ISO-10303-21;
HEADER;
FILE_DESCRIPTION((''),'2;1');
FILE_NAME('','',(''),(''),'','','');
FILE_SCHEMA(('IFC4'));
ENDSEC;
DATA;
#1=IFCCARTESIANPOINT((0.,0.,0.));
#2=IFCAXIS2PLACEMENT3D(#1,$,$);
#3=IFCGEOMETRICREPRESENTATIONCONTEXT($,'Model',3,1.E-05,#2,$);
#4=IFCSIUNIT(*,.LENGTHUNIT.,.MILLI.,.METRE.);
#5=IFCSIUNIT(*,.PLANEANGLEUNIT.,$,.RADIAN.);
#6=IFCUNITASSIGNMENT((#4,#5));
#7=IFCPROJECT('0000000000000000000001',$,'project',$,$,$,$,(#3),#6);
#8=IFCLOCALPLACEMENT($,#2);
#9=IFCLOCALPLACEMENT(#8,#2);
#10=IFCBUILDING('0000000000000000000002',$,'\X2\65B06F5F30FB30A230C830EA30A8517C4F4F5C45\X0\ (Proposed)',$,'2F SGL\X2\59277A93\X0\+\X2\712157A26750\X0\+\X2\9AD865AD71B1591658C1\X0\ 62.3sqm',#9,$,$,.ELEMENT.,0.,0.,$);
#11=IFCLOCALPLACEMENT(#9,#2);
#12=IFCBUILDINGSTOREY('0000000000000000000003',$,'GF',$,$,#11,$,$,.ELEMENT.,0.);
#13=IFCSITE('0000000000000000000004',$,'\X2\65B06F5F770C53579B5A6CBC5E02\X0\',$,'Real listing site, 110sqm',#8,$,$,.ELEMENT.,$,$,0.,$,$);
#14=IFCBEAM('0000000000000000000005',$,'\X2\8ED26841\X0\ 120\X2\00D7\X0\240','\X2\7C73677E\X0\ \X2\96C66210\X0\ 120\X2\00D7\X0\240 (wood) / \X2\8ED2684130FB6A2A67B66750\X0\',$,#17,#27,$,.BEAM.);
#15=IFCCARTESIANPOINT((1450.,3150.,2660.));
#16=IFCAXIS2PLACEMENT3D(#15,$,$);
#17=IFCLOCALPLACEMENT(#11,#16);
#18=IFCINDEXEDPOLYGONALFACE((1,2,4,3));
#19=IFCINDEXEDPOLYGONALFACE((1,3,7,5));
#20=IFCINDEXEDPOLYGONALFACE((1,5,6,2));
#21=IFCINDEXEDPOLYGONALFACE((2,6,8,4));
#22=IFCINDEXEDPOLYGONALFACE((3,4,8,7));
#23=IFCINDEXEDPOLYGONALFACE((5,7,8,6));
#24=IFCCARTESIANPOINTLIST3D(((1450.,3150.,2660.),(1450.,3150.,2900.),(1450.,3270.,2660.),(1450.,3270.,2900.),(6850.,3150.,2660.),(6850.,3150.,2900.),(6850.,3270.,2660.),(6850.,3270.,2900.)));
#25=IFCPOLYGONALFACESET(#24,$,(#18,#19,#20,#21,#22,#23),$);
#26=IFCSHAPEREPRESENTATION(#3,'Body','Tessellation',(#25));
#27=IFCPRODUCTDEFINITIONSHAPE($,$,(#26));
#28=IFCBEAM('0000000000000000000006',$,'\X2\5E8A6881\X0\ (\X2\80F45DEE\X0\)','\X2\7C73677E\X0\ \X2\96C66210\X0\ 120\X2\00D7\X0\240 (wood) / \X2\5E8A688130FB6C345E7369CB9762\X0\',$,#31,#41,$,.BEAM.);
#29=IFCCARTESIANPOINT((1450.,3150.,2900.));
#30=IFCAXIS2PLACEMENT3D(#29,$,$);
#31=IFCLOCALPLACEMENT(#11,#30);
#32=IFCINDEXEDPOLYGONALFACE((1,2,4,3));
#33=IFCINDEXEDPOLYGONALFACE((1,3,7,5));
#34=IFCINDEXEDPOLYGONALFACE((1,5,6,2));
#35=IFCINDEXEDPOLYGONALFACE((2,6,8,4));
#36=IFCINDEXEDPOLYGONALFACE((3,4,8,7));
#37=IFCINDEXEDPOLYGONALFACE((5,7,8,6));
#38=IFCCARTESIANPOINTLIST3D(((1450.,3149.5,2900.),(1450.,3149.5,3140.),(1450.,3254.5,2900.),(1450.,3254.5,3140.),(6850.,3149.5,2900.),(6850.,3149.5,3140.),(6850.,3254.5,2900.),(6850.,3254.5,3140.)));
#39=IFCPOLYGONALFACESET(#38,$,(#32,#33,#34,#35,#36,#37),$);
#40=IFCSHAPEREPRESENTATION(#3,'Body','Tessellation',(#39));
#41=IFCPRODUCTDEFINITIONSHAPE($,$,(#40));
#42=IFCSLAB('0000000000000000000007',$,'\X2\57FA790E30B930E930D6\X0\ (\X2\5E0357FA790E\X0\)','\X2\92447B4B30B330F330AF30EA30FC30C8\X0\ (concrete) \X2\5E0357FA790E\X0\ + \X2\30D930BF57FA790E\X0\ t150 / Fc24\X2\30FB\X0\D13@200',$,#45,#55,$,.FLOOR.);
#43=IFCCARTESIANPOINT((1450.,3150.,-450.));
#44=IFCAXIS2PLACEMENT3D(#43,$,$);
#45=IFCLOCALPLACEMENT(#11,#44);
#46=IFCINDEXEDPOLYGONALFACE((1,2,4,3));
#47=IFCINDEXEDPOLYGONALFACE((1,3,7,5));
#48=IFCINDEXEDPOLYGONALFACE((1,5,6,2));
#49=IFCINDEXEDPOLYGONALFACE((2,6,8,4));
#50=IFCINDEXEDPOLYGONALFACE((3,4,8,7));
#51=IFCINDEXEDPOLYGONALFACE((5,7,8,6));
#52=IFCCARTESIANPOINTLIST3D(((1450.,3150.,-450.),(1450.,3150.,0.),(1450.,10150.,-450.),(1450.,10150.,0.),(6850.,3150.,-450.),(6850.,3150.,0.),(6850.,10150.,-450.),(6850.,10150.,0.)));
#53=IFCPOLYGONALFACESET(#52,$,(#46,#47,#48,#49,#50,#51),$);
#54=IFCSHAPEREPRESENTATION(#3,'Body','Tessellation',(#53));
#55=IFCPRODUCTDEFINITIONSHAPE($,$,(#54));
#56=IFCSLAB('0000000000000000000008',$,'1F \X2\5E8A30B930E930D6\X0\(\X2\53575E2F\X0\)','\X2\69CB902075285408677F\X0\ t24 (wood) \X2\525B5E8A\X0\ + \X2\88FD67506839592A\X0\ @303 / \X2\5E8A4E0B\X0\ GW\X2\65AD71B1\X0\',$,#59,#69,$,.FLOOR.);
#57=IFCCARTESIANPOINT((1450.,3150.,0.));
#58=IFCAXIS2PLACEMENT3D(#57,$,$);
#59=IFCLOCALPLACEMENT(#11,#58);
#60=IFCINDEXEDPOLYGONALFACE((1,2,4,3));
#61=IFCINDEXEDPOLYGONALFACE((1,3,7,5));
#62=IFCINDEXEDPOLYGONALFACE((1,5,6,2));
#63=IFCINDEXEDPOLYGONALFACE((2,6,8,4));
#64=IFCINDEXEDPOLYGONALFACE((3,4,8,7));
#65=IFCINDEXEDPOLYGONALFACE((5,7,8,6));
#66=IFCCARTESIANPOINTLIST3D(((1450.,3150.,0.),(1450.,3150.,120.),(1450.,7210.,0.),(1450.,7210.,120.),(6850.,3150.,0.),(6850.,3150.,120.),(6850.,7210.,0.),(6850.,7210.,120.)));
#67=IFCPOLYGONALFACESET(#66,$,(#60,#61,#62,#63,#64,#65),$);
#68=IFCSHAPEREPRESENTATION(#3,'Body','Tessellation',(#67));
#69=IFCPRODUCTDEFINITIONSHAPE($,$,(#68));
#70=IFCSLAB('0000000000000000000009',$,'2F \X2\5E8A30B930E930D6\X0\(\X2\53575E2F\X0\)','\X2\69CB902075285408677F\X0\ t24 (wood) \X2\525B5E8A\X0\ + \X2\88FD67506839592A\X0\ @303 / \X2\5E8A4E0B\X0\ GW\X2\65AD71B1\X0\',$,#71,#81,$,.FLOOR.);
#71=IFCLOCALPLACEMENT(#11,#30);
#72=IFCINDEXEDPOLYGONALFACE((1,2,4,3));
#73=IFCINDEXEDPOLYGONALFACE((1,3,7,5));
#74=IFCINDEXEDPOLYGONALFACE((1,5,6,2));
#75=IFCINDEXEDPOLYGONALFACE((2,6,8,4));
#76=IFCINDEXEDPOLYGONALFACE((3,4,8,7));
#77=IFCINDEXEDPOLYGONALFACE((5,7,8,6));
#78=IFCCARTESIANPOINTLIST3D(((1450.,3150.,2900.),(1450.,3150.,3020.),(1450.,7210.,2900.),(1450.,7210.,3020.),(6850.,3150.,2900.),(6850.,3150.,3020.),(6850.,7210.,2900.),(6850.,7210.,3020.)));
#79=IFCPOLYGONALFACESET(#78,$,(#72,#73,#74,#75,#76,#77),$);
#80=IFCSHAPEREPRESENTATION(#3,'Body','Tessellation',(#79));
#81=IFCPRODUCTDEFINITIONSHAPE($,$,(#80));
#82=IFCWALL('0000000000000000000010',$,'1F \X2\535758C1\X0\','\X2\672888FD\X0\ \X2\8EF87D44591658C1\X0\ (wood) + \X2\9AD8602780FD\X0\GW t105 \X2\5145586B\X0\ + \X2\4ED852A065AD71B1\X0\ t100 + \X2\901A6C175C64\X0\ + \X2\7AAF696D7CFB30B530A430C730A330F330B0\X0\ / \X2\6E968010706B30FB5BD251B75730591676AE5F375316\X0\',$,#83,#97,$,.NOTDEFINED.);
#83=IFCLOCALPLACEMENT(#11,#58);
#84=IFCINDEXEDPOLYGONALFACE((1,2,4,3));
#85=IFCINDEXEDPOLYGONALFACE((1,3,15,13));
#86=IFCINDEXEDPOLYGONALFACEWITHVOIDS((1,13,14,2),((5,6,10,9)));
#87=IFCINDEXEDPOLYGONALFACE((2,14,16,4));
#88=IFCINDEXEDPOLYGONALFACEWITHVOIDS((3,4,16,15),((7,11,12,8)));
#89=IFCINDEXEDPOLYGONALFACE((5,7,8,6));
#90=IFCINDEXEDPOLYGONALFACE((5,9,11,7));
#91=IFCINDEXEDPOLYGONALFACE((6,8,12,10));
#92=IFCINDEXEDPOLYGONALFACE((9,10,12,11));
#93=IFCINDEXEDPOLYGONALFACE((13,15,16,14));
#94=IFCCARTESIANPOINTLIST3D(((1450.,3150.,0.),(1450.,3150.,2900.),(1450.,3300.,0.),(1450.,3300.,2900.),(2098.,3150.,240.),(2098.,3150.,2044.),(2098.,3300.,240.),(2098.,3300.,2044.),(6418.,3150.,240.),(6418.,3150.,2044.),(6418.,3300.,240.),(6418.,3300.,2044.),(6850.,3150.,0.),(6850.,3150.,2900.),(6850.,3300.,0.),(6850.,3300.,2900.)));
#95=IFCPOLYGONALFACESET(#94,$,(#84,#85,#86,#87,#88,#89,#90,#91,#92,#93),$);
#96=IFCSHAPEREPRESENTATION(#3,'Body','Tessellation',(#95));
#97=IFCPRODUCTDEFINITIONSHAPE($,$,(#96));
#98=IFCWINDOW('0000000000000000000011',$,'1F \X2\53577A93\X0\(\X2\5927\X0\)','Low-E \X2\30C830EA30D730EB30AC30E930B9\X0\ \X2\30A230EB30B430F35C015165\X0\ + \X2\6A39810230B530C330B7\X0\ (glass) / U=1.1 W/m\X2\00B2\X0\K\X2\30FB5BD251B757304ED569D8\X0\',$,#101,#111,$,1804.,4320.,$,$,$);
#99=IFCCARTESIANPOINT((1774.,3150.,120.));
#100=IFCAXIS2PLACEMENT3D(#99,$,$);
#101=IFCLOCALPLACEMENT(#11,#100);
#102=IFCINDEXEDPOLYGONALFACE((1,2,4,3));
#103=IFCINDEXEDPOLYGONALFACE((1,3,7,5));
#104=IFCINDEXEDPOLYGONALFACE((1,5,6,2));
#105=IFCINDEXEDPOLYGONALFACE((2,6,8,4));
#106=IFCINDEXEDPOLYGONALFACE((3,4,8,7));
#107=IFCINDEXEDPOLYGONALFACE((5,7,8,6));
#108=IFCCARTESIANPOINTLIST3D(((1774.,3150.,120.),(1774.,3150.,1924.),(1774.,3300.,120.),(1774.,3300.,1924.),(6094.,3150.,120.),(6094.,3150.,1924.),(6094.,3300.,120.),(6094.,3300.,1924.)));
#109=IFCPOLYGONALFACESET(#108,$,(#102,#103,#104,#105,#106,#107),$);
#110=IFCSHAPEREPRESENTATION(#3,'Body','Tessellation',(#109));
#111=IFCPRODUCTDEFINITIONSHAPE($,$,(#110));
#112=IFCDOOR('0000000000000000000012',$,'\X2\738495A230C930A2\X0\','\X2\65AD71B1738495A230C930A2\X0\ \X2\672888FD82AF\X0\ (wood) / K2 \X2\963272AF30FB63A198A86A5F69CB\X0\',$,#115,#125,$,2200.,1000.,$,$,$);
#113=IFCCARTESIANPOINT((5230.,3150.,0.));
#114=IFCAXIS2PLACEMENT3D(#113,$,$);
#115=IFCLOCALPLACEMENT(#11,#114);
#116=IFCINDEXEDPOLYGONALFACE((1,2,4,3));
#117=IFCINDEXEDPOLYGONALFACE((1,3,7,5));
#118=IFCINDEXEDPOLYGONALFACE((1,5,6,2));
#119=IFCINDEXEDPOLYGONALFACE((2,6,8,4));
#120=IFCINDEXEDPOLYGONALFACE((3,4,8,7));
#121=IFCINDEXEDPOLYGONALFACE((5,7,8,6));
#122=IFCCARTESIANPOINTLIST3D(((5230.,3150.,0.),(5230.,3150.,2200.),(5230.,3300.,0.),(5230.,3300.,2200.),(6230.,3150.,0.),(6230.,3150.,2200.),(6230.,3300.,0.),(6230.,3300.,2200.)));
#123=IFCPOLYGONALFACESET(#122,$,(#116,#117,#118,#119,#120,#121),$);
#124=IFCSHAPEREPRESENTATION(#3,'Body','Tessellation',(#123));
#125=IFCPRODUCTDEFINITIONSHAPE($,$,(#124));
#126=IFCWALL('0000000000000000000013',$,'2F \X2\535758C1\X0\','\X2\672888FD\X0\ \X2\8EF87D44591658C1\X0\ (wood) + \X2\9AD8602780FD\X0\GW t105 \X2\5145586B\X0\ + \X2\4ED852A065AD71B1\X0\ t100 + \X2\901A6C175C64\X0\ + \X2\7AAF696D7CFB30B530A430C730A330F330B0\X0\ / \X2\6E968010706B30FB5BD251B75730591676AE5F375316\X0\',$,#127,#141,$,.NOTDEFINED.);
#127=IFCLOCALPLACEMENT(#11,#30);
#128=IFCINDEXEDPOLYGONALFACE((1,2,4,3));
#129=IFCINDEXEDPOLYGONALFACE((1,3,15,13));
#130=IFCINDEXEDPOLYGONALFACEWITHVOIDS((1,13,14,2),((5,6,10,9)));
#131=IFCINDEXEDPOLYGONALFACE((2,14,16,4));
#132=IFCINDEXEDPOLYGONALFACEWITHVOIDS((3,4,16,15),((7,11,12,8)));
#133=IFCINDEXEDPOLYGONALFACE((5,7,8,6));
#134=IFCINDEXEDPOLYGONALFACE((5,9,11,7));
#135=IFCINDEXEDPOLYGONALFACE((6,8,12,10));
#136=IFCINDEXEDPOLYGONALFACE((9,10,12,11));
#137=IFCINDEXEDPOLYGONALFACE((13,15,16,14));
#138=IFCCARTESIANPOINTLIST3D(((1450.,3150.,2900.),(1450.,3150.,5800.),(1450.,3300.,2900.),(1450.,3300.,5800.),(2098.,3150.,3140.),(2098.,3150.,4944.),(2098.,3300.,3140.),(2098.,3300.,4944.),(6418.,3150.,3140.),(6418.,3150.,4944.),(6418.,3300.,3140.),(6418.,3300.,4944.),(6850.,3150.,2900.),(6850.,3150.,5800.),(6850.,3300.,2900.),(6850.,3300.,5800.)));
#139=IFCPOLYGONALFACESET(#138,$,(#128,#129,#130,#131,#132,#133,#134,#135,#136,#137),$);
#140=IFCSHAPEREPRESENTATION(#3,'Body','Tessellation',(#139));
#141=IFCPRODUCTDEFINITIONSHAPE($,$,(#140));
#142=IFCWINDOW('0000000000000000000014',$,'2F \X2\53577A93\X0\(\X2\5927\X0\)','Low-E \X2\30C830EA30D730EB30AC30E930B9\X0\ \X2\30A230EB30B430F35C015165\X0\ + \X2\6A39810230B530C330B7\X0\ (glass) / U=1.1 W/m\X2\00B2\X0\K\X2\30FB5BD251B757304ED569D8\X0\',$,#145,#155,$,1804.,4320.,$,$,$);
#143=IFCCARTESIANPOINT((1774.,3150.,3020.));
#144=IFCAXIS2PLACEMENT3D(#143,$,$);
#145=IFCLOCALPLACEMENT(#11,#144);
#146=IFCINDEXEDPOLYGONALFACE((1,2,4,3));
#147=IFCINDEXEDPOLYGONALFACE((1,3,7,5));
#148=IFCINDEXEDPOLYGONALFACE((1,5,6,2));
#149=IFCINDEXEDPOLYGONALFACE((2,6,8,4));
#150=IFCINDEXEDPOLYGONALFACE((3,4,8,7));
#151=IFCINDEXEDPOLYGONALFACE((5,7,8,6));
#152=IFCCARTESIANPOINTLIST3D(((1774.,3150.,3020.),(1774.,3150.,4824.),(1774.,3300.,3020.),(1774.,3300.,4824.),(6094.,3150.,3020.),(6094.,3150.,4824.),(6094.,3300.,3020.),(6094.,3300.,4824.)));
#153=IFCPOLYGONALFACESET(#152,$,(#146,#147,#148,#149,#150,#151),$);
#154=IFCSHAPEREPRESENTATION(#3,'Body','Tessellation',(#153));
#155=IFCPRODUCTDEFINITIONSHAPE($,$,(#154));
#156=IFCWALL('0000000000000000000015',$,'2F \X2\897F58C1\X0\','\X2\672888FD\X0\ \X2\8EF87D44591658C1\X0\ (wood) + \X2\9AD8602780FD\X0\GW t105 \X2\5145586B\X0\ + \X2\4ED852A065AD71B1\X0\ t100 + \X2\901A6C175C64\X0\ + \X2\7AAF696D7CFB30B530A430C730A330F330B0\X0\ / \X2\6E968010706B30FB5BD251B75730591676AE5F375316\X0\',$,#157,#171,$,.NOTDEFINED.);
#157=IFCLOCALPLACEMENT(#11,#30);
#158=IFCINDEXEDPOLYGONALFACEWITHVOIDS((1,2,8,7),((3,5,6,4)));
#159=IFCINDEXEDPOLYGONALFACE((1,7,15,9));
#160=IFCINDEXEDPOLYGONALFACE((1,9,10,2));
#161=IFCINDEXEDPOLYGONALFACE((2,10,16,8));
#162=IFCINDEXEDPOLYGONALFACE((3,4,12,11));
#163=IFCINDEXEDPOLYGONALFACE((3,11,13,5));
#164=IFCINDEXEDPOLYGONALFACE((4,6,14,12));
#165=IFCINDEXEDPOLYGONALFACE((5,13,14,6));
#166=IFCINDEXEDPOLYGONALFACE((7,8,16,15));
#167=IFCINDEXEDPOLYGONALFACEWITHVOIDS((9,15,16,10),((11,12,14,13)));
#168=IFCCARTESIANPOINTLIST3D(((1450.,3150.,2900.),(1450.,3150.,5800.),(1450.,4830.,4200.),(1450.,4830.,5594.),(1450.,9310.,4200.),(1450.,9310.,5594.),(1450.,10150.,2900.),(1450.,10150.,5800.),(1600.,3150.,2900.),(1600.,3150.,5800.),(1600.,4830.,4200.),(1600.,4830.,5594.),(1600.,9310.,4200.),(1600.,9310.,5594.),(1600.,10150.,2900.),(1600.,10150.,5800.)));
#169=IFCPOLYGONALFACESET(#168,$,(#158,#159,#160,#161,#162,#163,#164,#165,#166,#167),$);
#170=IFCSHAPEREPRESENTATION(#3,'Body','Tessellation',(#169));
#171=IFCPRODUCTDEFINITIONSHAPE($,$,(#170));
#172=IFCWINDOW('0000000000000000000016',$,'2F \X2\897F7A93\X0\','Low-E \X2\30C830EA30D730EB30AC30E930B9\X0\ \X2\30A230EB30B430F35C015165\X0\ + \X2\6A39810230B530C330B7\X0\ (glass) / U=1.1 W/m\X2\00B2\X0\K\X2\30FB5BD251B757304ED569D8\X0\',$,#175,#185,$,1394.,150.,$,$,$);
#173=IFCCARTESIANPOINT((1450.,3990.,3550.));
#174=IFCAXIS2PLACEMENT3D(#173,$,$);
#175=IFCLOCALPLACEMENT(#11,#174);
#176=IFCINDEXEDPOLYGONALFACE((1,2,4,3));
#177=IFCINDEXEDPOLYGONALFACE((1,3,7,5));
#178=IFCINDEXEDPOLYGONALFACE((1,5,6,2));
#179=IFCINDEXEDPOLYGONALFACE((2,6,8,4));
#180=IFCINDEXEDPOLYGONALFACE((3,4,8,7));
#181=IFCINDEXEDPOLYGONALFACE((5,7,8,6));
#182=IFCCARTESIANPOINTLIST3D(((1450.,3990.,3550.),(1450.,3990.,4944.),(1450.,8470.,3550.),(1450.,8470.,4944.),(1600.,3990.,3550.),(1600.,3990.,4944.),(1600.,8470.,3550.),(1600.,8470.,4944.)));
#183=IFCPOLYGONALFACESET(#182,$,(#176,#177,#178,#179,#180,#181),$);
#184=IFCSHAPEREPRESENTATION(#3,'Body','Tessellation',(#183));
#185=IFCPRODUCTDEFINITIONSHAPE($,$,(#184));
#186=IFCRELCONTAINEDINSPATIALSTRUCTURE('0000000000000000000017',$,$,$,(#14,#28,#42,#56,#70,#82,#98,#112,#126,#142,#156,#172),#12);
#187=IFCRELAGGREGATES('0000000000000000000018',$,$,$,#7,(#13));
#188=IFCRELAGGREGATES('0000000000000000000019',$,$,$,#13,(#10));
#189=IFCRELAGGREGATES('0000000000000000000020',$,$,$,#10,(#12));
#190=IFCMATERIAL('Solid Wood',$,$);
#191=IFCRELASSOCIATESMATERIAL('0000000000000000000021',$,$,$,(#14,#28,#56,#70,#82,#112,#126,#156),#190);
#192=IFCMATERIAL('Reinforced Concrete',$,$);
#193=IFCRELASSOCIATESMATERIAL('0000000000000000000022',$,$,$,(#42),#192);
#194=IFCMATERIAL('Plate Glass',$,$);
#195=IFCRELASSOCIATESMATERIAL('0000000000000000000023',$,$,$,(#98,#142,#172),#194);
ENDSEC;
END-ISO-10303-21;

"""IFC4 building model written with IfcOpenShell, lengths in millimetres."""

from ifc_helpers import new_model, si_unit, frame, frame_2d, origin, place, context, project, spatial, rectangle, extrude, material, element, fill, save


model = new_model("IFC4")

# Units and contexts
model_context = context("Model", 3, precision=1e-05, world=origin())
ifc_project = project(units=[si_unit("LENGTHUNIT", "METRE", prefix="MILLI"), si_unit("PLANEANGLEUNIT", "RADIAN")], contexts=[model_context])

# Site, building, storey
site_placement = place(None, origin())
site = spatial("IfcSite", under=ifc_project, at=site_placement, Name="新潟県南魚沼市", ObjectType="Real listing site, 110sqm", CompositionType="ELEMENT", RefElevation=0.0)
building_placement = place(site_placement, origin())
building = spatial("IfcBuilding", under=site, at=building_placement, Name="新潟・アトリエ兼住居 (Proposed)", ObjectType="2F SGL大窓+無垢材+高断熱外壁 62.3sqm", CompositionType="ELEMENT", ElevationOfRefHeight=0.0, ElevationOfTerrain=0.0)
storey_placement = place(building_placement, origin())
storey = spatial("IfcBuildingStorey", under=building, at=storey_placement, Name="GF", CompositionType="ELEMENT", Elevation=0.0)

# Shared definitions
ifc_material_1 = material(Name="Solid Wood")

# Beams
beam_1_placement = place(storey_placement, frame((1450.0, 3150.0, 2660.0)))
element("IfcBeam", 1, at=beam_1_placement, inside=storey, material=ifc_material_1, Name="軒桁 120×240", Description="米松 集成 120×240 (wood) / 軒桁・横架材", PredefinedType="BEAM", context=model_context, shape_type="SweptSolid", body=[
    extrude(rectangle(XDim=5400.0, YDim=120.0, at=frame_2d((2700.0, 60.0))), frame((1450.0, 3150.0, 2660.0)), (0.0, 0.0, 1.0), 240.0),
])
beam_2_placement = place(storey_placement, frame((1450.0, 3150.0, 2900.0)))
element("IfcBeam", 2, at=beam_2_placement, inside=storey, material=ifc_material_1, Name="床梁 (胴差)", Description="米松 集成 120×240 (wood) / 床梁・水平構面", PredefinedType="BEAM", context=model_context, shape_type="SweptSolid", body=[
    extrude(rectangle(XDim=5400.0, YDim=105.0, at=frame_2d((2700.0, 52.0))), frame((1450.0, 3150.0, 2900.0)), (0.0, 0.0, 1.0), 240.0),
])

# Slabs
ifc_material_2 = material(Name="Reinforced Concrete")
slab_1_placement = place(storey_placement, frame((1450.0, 3150.0, -450.0)))
element("IfcSlab", 3, at=slab_1_placement, inside=storey, material=ifc_material_2, Name="基礎スラブ (布基礎)", Description="鉄筋コンクリート (concrete) 布基礎 + ベタ基礎 t150 / Fc24・D13@200", PredefinedType="FLOOR", context=model_context, shape_type="SweptSolid", body=[
    extrude(rectangle(XDim=5400.0, YDim=7000.0, at=frame_2d((2700.0, 3500.0))), frame((1450.0, 3150.0, -450.0)), (0.0, 0.0, 1.0), 450.0),
])
slab_2_placement = place(storey_placement, frame((1450.0, 3150.0, 0.0)))
element("IfcSlab", 4, at=slab_2_placement, inside=storey, material=ifc_material_1, Name="1F 床スラブ(南帯)", Description="構造用合板 t24 (wood) 剛床 + 製材根太 @303 / 床下 GW断熱", PredefinedType="FLOOR", context=model_context, shape_type="SweptSolid", body=[
    extrude(rectangle(XDim=5400.0, YDim=4060.0, at=frame_2d((2700.0, 2030.0))), frame((1450.0, 3150.0, 0.0)), (0.0, 0.0, 1.0), 120.0),
])
slab_3_placement = place(storey_placement, frame((1450.0, 3150.0, 2900.0)))
element("IfcSlab", 5, at=slab_3_placement, inside=storey, material=ifc_material_1, Name="2F 床スラブ(南帯)", Description="構造用合板 t24 (wood) 剛床 + 製材根太 @303 / 床下 GW断熱", PredefinedType="FLOOR", context=model_context, shape_type="SweptSolid", body=[
    extrude(rectangle(XDim=5400.0, YDim=4060.0, at=frame_2d((2700.0, 2030.0))), frame((1450.0, 3150.0, 2900.0)), (0.0, 0.0, 1.0), 120.0),
])

# Wall, openings, window, door
wall_1_placement = place(storey_placement, frame((1450.0, 3150.0, 0.0)))
wall_1 = element("IfcWall", 6, at=wall_1_placement, inside=storey, material=ifc_material_1, Name="1F 南壁", Description="木製 軸組外壁 (wood) + 高性能GW t105 充填 + 付加断熱 t100 + 通気層 + 窯業系サイディング / 準耐火・寒冷地外皮強化", PredefinedType="NOTDEFINED", context=model_context, shape_type="SweptSolid", body=[
    extrude(rectangle(XDim=5400.0, YDim=150.0, at=frame_2d((2700.0, 75.0))), frame((1450.0, 3150.0, 0.0)), (0.0, 0.0, 1.0), 2900.0),
])
opening_1_placement = place(storey_placement, frame((1774.0, 3150.0, 120.0)))
opening_1 = element("IfcOpeningElement", 7, at=opening_1_placement, cuts=wall_1, PredefinedType="NOTDEFINED", context=model_context, shape_type="SweptSolid", body=[
    extrude(rectangle(XDim=4320.0, YDim=150.0, at=frame_2d((2160.0, 75.0))), frame((1774.0, 3150.0, 120.0)), (0.0, 0.0, 1.0), 1804.0),
])
opening_2_placement = place(storey_placement, frame((5230.0, 3150.0, 0.0)))
opening_2 = element("IfcOpeningElement", 8, at=opening_2_placement, cuts=wall_1, PredefinedType="NOTDEFINED", context=model_context, shape_type="SweptSolid", body=[
    extrude(rectangle(XDim=1000.0, YDim=150.0, at=frame_2d((500.0, 75.0))), frame((5230.0, 3150.0, 0.0)), (0.0, 0.0, 1.0), 2200.0),
])
ifc_material_3 = material(Name="Plate Glass")
window_1_placement = place(storey_placement, frame((1774.0, 3150.0, 120.0)))
window_1 = element("IfcWindow", 9, at=window_1_placement, inside=storey, material=ifc_material_3, Name="1F 南窓(大)", Description="Low-E トリプルガラス アルゴン封入 + 樹脂サッシ (glass) / U=1.1 W/m²K・寒冷地仕様", OverallHeight=1804.0, OverallWidth=4320.0, context=model_context, shape_type="SweptSolid", body=[
    extrude(rectangle(XDim=4320.0, YDim=150.0, at=frame_2d((2160.0, 75.0))), frame((1774.0, 3150.0, 120.0)), (0.0, 0.0, 1.0), 1804.0),
])
fill(opening_1, window_1)
door_placement = place(storey_placement, frame((5230.0, 3150.0, 0.0)))
door = element("IfcDoor", 10, at=door_placement, inside=storey, material=ifc_material_1, Name="玄関ドア", Description="断熱玄関ドア 木製芯 (wood) / K2 防犯・採風機構", OverallHeight=2200.0, OverallWidth=1000.0, context=model_context, shape_type="SweptSolid", body=[
    extrude(rectangle(XDim=1000.0, YDim=150.0, at=frame_2d((500.0, 75.0))), frame((5230.0, 3150.0, 0.0)), (0.0, 0.0, 1.0), 2200.0),
])
fill(opening_2, door)

# Walls, openings, windows
wall_2_placement = place(storey_placement, frame((1450.0, 3150.0, 2900.0)))
wall_2 = element("IfcWall", 11, at=wall_2_placement, inside=storey, material=ifc_material_1, Name="2F 南壁", Description="木製 軸組外壁 (wood) + 高性能GW t105 充填 + 付加断熱 t100 + 通気層 + 窯業系サイディング / 準耐火・寒冷地外皮強化", PredefinedType="NOTDEFINED", context=model_context, shape_type="SweptSolid", body=[
    extrude(rectangle(XDim=5400.0, YDim=150.0, at=frame_2d((2700.0, 75.0))), frame((1450.0, 3150.0, 2900.0)), (0.0, 0.0, 1.0), 2900.0),
])
opening_3_placement = place(storey_placement, frame((1774.0, 3150.0, 3020.0)))
opening_3 = element("IfcOpeningElement", 12, at=opening_3_placement, cuts=wall_2, PredefinedType="NOTDEFINED", context=model_context, shape_type="SweptSolid", body=[
    extrude(rectangle(XDim=4320.0, YDim=150.0, at=frame_2d((2160.0, 75.0))), frame((1774.0, 3150.0, 3020.0)), (0.0, 0.0, 1.0), 1804.0),
])
window_2_placement = place(storey_placement, frame((1774.0, 3150.0, 3020.0)))
window_2 = element("IfcWindow", 13, at=window_2_placement, inside=storey, material=ifc_material_3, Name="2F 南窓(大)", Description="Low-E トリプルガラス アルゴン封入 + 樹脂サッシ (glass) / U=1.1 W/m²K・寒冷地仕様", OverallHeight=1804.0, OverallWidth=4320.0, context=model_context, shape_type="SweptSolid", body=[
    extrude(rectangle(XDim=4320.0, YDim=150.0, at=frame_2d((2160.0, 75.0))), frame((1774.0, 3150.0, 3020.0)), (0.0, 0.0, 1.0), 1804.0),
])
fill(opening_3, window_2)
wall_3_placement = place(storey_placement, frame((1450.0, 3150.0, 2900.0)))
wall_3 = element("IfcWall", 14, at=wall_3_placement, inside=storey, material=ifc_material_1, Name="2F 西壁", Description="木製 軸組外壁 (wood) + 高性能GW t105 充填 + 付加断熱 t100 + 通気層 + 窯業系サイディング / 準耐火・寒冷地外皮強化", PredefinedType="NOTDEFINED", context=model_context, shape_type="SweptSolid", body=[
    extrude(rectangle(XDim=150.0, YDim=7000.0, at=frame_2d((75.0, 3500.0))), frame((1450.0, 3150.0, 2900.0)), (0.0, 0.0, 1.0), 2900.0),
])
opening_4_placement = place(storey_placement, frame((1450.0, 3990.0, 3550.0)))
opening_4 = element("IfcOpeningElement", 15, at=opening_4_placement, cuts=wall_3, PredefinedType="NOTDEFINED", context=model_context, shape_type="SweptSolid", body=[
    extrude(rectangle(XDim=150.0, YDim=4480.0, at=frame_2d((75.0, 2240.0))), frame((1450.0, 3990.0, 3550.0)), (0.0, 0.0, 1.0), 1394.0),
])
window_3_placement = place(storey_placement, frame((1450.0, 3990.0, 3550.0)))
window_3 = element("IfcWindow", 16, at=window_3_placement, inside=storey, material=ifc_material_3, Name="2F 西窓", Description="Low-E トリプルガラス アルゴン封入 + 樹脂サッシ (glass) / U=1.1 W/m²K・寒冷地仕様", OverallHeight=1394.0, OverallWidth=150.0, context=model_context, shape_type="SweptSolid", body=[
    extrude(rectangle(XDim=150.0, YDim=4480.0, at=frame_2d((75.0, 2240.0))), frame((1450.0, 3990.0, 3550.0)), (0.0, 0.0, 1.0), 1394.0),
])
fill(opening_4, window_3)

save(model, "model.ifc")
